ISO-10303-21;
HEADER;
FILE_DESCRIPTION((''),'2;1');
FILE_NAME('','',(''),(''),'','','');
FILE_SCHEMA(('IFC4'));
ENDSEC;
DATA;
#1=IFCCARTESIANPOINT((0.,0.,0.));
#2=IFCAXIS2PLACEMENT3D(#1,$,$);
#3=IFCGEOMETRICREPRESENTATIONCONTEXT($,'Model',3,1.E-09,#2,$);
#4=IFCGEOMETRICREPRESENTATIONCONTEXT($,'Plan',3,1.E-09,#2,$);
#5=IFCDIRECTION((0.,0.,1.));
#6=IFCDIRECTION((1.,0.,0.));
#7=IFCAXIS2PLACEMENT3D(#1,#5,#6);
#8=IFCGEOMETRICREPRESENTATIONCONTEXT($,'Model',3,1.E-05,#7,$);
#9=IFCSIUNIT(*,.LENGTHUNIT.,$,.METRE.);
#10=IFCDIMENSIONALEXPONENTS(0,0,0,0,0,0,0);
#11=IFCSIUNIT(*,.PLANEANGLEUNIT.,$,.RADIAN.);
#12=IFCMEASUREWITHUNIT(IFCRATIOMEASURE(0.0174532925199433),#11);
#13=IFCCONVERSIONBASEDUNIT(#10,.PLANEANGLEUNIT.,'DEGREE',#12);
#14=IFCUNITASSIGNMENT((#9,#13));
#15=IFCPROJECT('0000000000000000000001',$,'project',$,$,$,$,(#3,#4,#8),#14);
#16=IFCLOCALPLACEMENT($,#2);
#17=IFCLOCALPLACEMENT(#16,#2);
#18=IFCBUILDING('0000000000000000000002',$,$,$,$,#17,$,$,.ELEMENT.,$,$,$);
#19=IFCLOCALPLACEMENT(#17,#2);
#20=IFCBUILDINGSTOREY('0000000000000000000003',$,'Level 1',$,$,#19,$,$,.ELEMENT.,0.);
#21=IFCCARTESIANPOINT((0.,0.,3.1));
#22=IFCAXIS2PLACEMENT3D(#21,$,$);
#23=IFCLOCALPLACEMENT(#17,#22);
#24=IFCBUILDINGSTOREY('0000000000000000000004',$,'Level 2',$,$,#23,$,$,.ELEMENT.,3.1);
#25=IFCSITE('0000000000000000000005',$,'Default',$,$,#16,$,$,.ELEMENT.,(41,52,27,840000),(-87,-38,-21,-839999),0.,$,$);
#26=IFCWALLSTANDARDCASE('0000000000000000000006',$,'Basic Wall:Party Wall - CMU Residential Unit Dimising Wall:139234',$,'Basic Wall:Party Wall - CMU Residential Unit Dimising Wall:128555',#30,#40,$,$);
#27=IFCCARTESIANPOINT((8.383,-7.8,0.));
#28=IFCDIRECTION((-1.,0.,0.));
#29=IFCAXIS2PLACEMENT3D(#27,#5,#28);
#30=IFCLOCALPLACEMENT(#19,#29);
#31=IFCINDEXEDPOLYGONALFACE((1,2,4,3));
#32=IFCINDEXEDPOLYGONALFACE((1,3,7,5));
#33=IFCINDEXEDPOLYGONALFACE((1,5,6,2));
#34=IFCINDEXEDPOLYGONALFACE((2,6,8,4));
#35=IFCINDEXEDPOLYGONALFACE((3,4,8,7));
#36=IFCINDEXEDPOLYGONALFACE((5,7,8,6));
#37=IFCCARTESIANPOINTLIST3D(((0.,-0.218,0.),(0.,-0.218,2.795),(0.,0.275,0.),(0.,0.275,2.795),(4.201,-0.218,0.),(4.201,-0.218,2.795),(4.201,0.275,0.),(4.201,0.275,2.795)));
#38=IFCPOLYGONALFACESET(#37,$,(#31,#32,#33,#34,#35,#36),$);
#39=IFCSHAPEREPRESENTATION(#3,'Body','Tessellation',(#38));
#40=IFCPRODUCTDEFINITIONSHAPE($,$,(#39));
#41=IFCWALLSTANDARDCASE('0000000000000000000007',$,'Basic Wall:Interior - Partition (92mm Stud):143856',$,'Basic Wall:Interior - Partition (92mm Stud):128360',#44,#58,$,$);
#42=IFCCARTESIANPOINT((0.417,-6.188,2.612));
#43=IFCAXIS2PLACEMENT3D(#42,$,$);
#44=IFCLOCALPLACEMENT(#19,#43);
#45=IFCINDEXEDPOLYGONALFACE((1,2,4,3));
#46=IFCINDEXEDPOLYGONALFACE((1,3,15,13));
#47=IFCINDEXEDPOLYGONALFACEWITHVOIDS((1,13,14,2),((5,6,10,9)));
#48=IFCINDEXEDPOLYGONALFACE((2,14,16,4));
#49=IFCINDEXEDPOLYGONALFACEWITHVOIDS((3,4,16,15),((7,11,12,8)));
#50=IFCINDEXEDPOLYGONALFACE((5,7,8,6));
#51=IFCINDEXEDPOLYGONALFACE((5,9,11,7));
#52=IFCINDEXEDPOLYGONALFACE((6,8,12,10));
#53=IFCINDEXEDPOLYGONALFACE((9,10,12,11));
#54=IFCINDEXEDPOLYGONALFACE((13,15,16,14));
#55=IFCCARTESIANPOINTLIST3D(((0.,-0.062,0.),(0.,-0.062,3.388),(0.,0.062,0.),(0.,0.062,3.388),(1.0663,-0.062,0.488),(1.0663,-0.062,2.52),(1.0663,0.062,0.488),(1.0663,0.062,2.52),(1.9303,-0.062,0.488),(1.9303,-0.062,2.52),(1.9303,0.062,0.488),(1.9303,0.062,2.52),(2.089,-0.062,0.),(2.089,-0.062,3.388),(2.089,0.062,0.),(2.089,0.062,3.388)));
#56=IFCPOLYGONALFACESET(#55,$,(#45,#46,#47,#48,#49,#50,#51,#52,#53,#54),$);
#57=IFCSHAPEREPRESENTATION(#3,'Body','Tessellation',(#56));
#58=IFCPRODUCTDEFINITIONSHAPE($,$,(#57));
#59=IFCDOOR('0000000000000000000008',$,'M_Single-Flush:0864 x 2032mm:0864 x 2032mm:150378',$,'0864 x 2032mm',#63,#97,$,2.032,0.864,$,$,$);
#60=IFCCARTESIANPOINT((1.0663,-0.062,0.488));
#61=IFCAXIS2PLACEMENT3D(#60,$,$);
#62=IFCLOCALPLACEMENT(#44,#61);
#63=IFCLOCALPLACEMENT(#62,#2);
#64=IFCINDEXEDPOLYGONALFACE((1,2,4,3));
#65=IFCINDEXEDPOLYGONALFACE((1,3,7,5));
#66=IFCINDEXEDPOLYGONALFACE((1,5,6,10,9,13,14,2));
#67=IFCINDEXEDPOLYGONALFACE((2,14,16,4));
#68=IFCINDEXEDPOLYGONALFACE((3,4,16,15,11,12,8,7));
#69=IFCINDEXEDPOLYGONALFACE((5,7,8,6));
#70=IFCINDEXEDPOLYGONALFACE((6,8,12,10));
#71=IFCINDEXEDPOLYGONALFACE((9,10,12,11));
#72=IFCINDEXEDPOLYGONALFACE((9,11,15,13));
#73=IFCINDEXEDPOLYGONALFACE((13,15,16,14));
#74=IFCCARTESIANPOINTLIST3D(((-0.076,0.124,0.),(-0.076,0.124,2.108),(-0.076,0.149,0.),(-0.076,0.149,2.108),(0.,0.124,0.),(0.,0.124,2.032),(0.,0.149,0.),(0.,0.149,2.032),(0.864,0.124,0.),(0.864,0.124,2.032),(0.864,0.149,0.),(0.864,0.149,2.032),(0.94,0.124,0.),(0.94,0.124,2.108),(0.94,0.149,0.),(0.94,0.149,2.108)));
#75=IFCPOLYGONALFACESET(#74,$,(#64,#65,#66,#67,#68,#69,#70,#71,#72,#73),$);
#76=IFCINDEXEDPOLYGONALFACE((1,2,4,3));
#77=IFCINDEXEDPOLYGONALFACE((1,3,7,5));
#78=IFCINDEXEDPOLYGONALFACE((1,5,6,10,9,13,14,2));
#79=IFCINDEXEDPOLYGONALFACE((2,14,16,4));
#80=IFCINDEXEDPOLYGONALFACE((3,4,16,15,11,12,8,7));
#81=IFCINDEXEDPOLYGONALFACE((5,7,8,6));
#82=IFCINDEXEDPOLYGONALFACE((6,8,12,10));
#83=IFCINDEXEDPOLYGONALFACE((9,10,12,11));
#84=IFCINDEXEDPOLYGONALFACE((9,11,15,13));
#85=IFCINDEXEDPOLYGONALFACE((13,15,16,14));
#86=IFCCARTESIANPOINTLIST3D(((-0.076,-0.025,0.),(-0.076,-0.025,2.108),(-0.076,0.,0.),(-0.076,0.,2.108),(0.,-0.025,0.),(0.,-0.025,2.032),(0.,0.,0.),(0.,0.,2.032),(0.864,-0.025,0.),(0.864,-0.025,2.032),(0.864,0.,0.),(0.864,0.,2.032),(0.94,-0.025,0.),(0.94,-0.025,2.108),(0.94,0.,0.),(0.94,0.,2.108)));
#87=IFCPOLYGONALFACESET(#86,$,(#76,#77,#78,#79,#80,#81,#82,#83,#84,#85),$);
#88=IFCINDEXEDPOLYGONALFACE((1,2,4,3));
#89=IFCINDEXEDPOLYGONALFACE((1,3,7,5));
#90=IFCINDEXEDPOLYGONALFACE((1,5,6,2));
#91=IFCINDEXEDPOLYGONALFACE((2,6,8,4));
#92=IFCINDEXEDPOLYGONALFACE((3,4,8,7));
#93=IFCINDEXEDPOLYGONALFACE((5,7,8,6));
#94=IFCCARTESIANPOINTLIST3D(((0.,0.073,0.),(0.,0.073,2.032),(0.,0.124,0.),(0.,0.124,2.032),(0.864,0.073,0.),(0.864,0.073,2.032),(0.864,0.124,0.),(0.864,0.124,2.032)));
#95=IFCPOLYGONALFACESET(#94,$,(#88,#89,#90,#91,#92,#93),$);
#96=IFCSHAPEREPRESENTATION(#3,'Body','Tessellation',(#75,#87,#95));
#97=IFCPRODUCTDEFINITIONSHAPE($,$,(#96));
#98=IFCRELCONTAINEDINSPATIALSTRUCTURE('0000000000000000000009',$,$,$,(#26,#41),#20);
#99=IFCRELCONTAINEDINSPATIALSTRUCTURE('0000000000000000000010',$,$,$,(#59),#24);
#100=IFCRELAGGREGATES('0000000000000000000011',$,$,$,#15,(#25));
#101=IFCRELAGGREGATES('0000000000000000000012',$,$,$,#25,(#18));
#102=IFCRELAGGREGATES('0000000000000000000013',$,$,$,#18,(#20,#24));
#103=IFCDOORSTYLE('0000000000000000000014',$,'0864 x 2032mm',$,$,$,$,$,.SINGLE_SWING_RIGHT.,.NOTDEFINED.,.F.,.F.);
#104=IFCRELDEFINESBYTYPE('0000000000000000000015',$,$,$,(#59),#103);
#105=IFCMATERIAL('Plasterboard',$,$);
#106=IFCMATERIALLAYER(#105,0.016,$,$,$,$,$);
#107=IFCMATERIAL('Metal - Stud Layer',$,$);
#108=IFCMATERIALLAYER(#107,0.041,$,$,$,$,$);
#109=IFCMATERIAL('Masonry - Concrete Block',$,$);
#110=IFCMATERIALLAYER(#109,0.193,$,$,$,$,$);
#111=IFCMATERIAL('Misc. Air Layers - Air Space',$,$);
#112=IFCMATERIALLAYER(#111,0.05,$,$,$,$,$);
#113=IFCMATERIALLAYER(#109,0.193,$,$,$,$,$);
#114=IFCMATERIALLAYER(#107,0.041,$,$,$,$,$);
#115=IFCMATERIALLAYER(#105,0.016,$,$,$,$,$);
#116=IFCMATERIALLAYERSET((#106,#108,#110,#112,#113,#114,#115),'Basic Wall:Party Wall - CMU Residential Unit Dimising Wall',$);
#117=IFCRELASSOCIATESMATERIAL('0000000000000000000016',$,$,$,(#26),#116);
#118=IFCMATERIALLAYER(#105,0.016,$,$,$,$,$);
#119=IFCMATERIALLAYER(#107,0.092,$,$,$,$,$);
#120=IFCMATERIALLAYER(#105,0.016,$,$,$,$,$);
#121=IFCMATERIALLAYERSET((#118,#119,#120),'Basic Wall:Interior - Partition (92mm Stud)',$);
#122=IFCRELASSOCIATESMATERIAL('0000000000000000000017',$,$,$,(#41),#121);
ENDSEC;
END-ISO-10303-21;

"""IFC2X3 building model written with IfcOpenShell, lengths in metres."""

from ifc_helpers import new_model, entity, si_unit, converted_unit, frame, frame_2d, origin, origin_with_axes, origin_2d_with_axis, place, context, project, spatial, polyline, rectangle, outline, extrude, clip, bounded_halfspace, source, transform, mapped, material, layer, layer_set, layer_usage, type_object, type_shapes, element, fill, save


model = new_model("IFC2X3")

# Units and contexts
model_context_1 = context("Model", 3, precision=1e-09, world=origin())
plan_context = context("Plan", 3, precision=1e-09, world=origin())
model_context_2 = context("Model", 3, precision=1e-05, world=origin_with_axes())
ifc_project = project(units=[si_unit("LENGTHUNIT", "METRE"), converted_unit("PLANEANGLEUNIT", "DEGREE", entity("IfcRatioMeasure", 0.0174532925199433), si_unit("PLANEANGLEUNIT", "RADIAN"), dimensions=[0, 0, 0, 0, 0, 0, 0])], contexts=[model_context_1, plan_context, model_context_2])

# Site, building, storey
site_placement = place(None, origin())
site = spatial("IfcSite", under=ifc_project, at=site_placement, Name="Default", CompositionType="ELEMENT", RefLatitude=(41, 52, 27, 840000), RefLongitude=(-87, -38, -21, -839999), RefElevation=0.0)
building_placement = place(site_placement, origin())
building = spatial("IfcBuilding", under=site, at=building_placement, CompositionType="ELEMENT")
storey_1_placement = place(building_placement, origin())
storey_1 = spatial("IfcBuildingStorey", under=building, at=storey_1_placement, Name="Level 1", CompositionType="ELEMENT", Elevation=0.0)

# Shared definitions
ifc_material_1 = material(Name="Misc. Air Layers - Air Space")
ifc_material_2 = material(Name="Masonry - Concrete Block")
ifc_material_3 = material(Name="Metal - Stud Layer")
ifc_material_4 = material(Name="Plasterboard")

# Shared definitions
ifc_layer_1 = layer(ifc_material_4, 0.016)
ifc_layer_2 = layer(ifc_material_3, 0.092)
ifc_layer_3 = layer(ifc_material_4, 0.016)
ifc_layer_set_1 = layer_set([ifc_layer_1, ifc_layer_2, ifc_layer_3], Name="Basic Wall:Interior - Partition (92mm Stud)")

# Wall
ifc_layer_4 = layer(ifc_material_4, 0.016)
ifc_layer_5 = layer(ifc_material_3, 0.041)
ifc_layer_6 = layer(ifc_material_2, 0.193)
ifc_layer_7 = layer(ifc_material_1, 0.05)
ifc_layer_8 = layer(ifc_material_2, 0.193)
ifc_layer_9 = layer(ifc_material_3, 0.041)
ifc_layer_10 = layer(ifc_material_4, 0.016)
ifc_layer_set_2 = layer_set([ifc_layer_4, ifc_layer_5, ifc_layer_6, ifc_layer_7, ifc_layer_8, ifc_layer_9, ifc_layer_10], Name="Basic Wall:Party Wall - CMU Residential Unit Dimising Wall")
ifc_layer_usage_1 = layer_usage(ifc_layer_set_2, "AXIS2", "NEGATIVE", 0.275)
wall_1_placement = place(storey_1_placement, frame((8.383, -7.8, 0.0), z_axis=(0.0, 0.0, 1.0), x_axis=(-1.0, 0.0, 0.0)))
element("IfcWallStandardCase", 1, at=wall_1_placement, inside=storey_1, material=ifc_layer_usage_1, Name="Basic Wall:Party Wall - CMU Residential Unit Dimising Wall:139234", ObjectType="Basic Wall:Party Wall - CMU Residential Unit Dimising Wall:128555", context=model_context_1, shape_type="Clipping", body=[
    clip(clip(extrude(rectangle(XDim=4.201, YDim=0.55, at=frame_2d((2.1005, 0.0), x_axis=(-1.0, 0.0))), origin(), (0.0, 0.0, 1.0), 2.795), bounded_halfspace(frame((0.0, -0.218, 2.795), z_axis=(0.0, 1.0, 0.0), x_axis=(-1.0, 0.0, 0.0)), True, frame((0.0, -0.218, 2.795), z_axis=(0.0, 1.0, 0.0), x_axis=(-1.0, 0.0, 0.0)), polyline([(0.0, 0.0), (-3.708, 0.0), (-4.201, 0.0), (-4.201, -2.795), (0.0, -2.795), (0.0, 0.0)]))), bounded_halfspace(frame((4.201, 0.275, 0.0), z_axis=(-1.0, 0.0, 0.0), x_axis=(0.0, -1.0, 0.0)), True, frame((4.201, 0.275, 0.0), z_axis=(-1.0, 0.0, 0.0), x_axis=(0.0, -1.0, 0.0)), polyline([(0.0, 0.0), (0.493, 0.0), (0.493, 2.795), (0.0, 2.795), (0.0, 0.0)]))),
])

# Wall, opening
ifc_layer_usage_2 = layer_usage(ifc_layer_set_1, "AXIS2", "NEGATIVE", 0.062)
wall_2_placement = place(storey_1_placement, frame((0.417, -6.188, 2.612)))
wall_2 = element("IfcWallStandardCase", 2, at=wall_2_placement, inside=storey_1, material=ifc_layer_usage_2, Name="Basic Wall:Interior - Partition (92mm Stud):143856", ObjectType="Basic Wall:Interior - Partition (92mm Stud):128360", context=model_context_1, shape_type="SweptSolid", body=[
    extrude(rectangle(XDim=2.089, YDim=0.124, at=frame_2d((1.0445, 0.0), x_axis=(-1.0, 0.0))), origin(), (0.0, 0.0, 1.0), 3.388),
])
opening_1_placement = place(wall_2_placement, frame((1.0663, -0.062, 0.488)))
opening_1 = element("IfcOpeningElement", 3, at=opening_1_placement, cuts=wall_2, ObjectType="Opening", context=model_context_1, shape_type="SweptSolid", body=[
    extrude(rectangle(XDim=0.864, YDim=2.032, at=frame_2d((1.016, 0.432), x_axis=(0.0, 1.0))), frame((0.0, 0.0, 0.0), z_axis=(0.0, 1.0, 0.0), x_axis=(0.0, 0.0, 1.0)), (0.0, 0.0, 1.0), 0.124),
])

# Shared definitions
storey_2_placement = place(building_placement, frame((0.0, 0.0, 3.1)))
storey_2 = spatial("IfcBuildingStorey", under=building, at=storey_2_placement, Name="Level 2", CompositionType="ELEMENT", Elevation=3.1)

# Door
door_style_1 = type_object("IfcDoorStyle", Name="0864 x 2032mm", ConstructionType="NOTDEFINED", OperationType="SINGLE_SWING_RIGHT", ParameterTakesPrecedence=False, Sizeable=False)
shared_shape_1 = source(origin(), model_context_1, "Body", "SweptSolid", [
    extrude(outline(polyline([(-0.508, -1.073), (0.508, -1.073), (0.508, 1.035), (0.432, 1.035), (0.432, -0.997), (-0.432, -0.997), (-0.432, 1.035), (-0.508, 1.035), (-0.508, -1.073)])), frame((0.432, 0.124, 1.035), z_axis=(0.0, 1.0, 0.0), x_axis=(1.0, 0.0, 0.0)), (0.0, 0.0, 1.0), 0.025),
    extrude(outline(polyline([(-1.073, -0.508), (1.035, -0.508), (1.035, -0.432), (-0.997, -0.432), (-0.997, 0.432), (1.035, 0.432), (1.035, 0.508), (-1.073, 0.508), (-1.073, -0.508)])), frame((0.432, -0.025, 1.035), z_axis=(0.0, 1.0, 0.0), x_axis=(0.0, 0.0, -1.0)), (0.0, 0.0, 1.0), 0.025),
    extrude(rectangle(XDim=0.051, YDim=0.864, at=origin_2d_with_axis()), frame((0.432, 0.0985, 0.0), z_axis=(0.0, 0.0, 1.0), x_axis=(0.0, 1.0, 0.0)), (0.0, 0.0, 1.0), 2.032),
])
type_shapes(door_style_1, [shared_shape_1])
door_1_placement = place(opening_1_placement, origin())
door_1 = element("IfcDoor", 4, at=door_1_placement, inside=storey_2, type_object=door_style_1, Name="M_Single-Flush:0864 x 2032mm:0864 x 2032mm:150378", ObjectType="0864 x 2032mm", OverallHeight=2.032, OverallWidth=0.864, context=model_context_1, shape_type="MappedRepresentation", body=[
    mapped(shared_shape_1, transform((0.0, 0.0, 0.0), scale=1.0)),
])
fill(opening_1, door_1)

save(model, "model.ifc")
